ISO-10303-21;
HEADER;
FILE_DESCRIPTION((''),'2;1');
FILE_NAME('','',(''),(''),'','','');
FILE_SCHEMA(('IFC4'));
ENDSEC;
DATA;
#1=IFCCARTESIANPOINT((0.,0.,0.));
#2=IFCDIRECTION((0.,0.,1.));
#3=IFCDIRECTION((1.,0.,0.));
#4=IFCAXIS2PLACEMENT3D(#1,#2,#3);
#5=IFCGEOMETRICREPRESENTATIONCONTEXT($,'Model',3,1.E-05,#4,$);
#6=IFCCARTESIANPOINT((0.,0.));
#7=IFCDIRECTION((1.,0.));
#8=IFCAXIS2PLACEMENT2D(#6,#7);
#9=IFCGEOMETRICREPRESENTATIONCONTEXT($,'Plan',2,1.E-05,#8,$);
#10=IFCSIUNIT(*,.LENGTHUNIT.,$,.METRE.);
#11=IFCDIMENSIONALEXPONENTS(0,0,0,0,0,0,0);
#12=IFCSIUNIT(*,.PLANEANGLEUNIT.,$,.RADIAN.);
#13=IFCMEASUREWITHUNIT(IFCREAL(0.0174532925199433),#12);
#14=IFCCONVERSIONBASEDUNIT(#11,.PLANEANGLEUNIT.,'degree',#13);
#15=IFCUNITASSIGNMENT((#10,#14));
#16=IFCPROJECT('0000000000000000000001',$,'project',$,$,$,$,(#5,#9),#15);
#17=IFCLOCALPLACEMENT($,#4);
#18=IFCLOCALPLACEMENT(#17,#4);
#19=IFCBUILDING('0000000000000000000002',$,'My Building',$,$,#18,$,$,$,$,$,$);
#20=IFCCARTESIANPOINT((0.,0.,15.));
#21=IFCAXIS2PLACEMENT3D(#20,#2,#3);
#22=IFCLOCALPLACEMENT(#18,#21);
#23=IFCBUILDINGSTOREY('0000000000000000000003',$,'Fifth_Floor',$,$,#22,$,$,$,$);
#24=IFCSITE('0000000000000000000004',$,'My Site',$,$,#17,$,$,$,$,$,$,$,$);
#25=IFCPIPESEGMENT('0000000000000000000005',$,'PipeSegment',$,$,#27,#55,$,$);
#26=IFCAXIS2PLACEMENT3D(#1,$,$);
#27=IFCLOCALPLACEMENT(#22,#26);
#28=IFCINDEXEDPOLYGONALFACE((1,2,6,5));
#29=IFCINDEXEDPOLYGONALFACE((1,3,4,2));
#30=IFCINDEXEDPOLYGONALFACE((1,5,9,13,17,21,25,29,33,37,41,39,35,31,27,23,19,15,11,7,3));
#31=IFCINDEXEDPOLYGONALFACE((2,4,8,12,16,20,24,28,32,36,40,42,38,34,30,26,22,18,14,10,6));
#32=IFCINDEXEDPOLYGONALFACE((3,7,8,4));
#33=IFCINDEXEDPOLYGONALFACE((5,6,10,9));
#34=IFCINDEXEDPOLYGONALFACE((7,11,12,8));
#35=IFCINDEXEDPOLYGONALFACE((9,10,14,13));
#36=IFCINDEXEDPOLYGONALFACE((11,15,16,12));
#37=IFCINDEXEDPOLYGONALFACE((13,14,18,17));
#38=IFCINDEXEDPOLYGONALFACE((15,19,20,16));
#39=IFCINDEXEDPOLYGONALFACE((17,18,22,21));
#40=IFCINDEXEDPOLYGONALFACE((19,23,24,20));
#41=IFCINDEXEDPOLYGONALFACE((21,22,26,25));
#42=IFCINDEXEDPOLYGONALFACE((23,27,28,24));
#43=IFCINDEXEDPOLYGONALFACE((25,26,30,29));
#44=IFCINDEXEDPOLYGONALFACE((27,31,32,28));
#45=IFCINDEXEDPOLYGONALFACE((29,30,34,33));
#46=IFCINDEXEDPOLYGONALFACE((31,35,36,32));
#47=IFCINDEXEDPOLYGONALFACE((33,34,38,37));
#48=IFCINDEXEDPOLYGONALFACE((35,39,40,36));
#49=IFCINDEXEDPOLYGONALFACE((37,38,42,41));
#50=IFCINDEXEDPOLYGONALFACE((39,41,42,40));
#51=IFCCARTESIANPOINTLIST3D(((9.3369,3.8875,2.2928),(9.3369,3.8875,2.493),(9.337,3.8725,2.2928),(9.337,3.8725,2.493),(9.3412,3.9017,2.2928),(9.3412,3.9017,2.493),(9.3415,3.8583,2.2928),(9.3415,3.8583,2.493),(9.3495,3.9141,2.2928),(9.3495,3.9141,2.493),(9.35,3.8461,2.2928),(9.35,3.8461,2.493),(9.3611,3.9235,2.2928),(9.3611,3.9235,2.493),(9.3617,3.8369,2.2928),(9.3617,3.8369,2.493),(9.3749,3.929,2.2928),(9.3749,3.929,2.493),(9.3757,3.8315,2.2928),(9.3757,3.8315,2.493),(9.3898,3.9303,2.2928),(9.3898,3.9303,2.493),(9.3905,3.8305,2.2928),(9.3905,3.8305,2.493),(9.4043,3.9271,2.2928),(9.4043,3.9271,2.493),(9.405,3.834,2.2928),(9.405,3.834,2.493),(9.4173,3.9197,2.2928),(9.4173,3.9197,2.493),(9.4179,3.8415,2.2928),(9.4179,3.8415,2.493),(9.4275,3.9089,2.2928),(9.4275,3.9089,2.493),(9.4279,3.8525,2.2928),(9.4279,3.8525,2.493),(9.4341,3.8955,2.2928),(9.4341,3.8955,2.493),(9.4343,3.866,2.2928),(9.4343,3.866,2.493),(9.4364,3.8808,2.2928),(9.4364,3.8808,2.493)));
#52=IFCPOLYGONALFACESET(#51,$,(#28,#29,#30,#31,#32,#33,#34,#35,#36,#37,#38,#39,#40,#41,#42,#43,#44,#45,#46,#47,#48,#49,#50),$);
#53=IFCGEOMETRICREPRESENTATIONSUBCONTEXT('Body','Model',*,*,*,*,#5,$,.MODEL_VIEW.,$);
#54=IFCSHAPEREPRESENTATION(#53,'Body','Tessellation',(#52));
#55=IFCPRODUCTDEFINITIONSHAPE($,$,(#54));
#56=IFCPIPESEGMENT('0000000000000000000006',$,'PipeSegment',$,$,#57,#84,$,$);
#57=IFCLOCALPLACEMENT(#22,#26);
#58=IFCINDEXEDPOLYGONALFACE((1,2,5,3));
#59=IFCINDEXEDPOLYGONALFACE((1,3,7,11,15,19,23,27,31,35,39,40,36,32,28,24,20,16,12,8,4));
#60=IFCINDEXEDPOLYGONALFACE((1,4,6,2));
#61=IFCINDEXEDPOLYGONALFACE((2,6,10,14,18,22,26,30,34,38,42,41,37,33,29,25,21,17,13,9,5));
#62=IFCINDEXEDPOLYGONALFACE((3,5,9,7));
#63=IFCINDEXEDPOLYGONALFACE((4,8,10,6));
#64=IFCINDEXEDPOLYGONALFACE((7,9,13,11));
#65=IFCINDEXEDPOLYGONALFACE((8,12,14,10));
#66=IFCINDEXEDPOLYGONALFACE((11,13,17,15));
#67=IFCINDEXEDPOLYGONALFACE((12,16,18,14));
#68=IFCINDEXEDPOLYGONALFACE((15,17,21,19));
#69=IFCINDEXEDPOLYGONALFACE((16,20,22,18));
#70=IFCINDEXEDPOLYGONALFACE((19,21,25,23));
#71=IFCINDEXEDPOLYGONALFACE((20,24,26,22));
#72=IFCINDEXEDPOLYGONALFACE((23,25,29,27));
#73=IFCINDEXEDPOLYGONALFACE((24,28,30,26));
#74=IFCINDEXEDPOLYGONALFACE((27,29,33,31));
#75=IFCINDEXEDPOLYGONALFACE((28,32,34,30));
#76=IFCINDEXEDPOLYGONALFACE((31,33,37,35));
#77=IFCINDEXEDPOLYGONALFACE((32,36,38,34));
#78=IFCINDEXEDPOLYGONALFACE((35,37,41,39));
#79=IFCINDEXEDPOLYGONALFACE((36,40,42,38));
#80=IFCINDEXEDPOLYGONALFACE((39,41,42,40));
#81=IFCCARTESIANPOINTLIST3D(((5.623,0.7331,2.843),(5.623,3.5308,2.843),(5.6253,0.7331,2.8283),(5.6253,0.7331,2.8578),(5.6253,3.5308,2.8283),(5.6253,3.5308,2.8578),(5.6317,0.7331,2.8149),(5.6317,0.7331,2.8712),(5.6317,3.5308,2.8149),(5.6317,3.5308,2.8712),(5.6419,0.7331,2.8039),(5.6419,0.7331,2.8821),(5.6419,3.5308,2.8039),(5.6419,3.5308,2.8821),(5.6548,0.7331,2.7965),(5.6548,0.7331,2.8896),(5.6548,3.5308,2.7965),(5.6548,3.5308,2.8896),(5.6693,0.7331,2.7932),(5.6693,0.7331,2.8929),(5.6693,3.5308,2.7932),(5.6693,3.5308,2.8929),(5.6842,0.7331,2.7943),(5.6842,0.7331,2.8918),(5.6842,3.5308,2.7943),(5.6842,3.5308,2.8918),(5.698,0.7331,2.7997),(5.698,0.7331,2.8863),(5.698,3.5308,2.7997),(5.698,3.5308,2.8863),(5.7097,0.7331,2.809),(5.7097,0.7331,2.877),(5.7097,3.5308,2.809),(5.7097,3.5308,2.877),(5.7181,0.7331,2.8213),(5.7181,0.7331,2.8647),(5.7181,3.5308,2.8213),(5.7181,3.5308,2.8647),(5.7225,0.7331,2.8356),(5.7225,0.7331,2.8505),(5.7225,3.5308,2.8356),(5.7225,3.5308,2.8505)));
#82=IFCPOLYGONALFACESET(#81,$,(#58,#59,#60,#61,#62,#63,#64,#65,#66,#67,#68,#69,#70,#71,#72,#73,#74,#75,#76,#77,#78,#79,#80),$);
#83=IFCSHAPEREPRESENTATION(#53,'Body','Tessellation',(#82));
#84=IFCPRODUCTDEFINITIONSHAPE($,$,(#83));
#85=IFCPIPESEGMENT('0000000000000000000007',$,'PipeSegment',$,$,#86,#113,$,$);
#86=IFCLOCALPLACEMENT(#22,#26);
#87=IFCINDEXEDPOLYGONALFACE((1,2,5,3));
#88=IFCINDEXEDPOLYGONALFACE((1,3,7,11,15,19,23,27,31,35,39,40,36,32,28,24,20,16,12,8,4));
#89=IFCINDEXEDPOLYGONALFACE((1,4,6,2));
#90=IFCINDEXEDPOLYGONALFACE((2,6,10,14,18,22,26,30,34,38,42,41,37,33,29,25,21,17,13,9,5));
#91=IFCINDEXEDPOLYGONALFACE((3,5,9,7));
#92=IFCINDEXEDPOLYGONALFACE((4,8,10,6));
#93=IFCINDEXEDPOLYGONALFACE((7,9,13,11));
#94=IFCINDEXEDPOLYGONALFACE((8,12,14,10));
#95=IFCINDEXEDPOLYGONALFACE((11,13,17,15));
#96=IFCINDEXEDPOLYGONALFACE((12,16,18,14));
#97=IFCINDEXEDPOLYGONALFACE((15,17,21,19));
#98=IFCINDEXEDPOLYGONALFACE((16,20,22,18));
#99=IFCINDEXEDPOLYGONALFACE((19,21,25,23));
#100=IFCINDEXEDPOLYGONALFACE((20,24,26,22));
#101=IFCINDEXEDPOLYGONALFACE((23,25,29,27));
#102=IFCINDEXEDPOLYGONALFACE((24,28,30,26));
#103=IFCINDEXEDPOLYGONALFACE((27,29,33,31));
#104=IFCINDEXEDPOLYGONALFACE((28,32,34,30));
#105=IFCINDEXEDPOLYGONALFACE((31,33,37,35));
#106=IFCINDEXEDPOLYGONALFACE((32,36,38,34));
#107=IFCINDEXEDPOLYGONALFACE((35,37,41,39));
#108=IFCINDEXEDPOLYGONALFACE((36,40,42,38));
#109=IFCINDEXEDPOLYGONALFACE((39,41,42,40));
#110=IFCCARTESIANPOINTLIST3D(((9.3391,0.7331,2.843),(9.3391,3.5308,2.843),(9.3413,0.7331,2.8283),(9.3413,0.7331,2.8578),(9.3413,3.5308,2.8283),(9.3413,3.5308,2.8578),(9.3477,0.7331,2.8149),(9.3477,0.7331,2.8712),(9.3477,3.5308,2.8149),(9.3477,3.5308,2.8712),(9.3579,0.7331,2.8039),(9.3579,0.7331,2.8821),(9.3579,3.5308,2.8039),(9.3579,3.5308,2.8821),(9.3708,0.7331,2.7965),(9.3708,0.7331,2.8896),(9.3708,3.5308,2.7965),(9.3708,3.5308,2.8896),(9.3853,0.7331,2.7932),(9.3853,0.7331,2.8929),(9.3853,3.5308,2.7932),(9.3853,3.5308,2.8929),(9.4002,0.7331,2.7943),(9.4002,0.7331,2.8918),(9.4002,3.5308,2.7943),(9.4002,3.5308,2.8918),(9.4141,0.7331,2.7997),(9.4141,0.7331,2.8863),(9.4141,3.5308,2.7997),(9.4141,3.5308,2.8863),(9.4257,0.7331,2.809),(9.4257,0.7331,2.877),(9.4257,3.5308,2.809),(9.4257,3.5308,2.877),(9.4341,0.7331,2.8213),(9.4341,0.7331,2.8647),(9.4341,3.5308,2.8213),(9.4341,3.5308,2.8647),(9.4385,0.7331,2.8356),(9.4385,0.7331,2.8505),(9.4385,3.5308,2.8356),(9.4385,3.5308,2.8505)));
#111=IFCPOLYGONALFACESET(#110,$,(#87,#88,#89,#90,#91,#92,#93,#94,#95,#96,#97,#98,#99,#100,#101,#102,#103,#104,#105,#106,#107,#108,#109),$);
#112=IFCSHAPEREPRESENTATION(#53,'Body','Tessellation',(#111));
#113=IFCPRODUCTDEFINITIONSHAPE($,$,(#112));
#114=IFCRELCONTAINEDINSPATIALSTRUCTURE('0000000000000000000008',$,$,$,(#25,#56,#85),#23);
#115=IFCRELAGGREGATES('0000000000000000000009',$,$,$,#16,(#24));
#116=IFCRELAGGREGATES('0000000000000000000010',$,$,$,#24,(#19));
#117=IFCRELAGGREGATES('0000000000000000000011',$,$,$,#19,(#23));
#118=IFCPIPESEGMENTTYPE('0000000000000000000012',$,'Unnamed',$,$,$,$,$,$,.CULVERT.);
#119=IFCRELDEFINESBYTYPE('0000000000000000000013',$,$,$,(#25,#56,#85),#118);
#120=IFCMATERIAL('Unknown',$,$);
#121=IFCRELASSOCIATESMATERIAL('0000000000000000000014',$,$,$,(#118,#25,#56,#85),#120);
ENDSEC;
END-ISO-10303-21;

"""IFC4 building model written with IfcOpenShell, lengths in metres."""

from ifc_helpers import new_model, entity, si_unit, converted_unit, frame, origin_with_axes, origin_2d_with_axis, place, context, subcontext, project, spatial, circle, extrude, material, material_profile, profile_set, profile_usage, type_object, element, save


model = new_model("IFC4")

# Units and contexts
model_context = context("Model", 3, precision=1e-05, world=origin_with_axes())
plan_context = context("Plan", 2, precision=1e-05, world=origin_2d_with_axis())
body_context = subcontext(model_context, "Body", "Model", "MODEL_VIEW")
ifc_project = project(units=[si_unit("LENGTHUNIT", "METRE"), converted_unit("PLANEANGLEUNIT", "degree", entity("IfcReal", 0.0174532925199433), si_unit("PLANEANGLEUNIT", "RADIAN"), dimensions=[0, 0, 0, 0, 0, 0, 0])], contexts=[model_context, plan_context])

# Site, building, storey
site_placement = place(None, origin_with_axes())
site = spatial("IfcSite", under=ifc_project, at=site_placement, Name="My Site")
building_placement = place(site_placement, origin_with_axes())
building = spatial("IfcBuilding", under=site, at=building_placement, Name="My Building")
storey_placement = place(building_placement, frame((0.0, 0.0, 15.0), z_axis=(0.0, 0.0, 1.0), x_axis=(1.0, 0.0, 0.0)))
storey = spatial("IfcBuildingStorey", under=building, at=storey_placement, Name="Fifth_Floor")

# Pipe segments
ifc_material = material(Name="Unknown")
ifc_material_profile = material_profile(ifc_material, circle(Radius=0.05))
ifc_profile_set = profile_set([ifc_material_profile])
ifc_profile_usage_1 = profile_usage(ifc_profile_set, cardinal=5)
pipe_segment_type = type_object("IfcPipeSegmentType", Name="Unnamed", PredefinedType="CULVERT", material=ifc_profile_set)
pipe_segment_1_placement = place(storey_placement, frame((9.3864, 3.8804, 2.493), z_axis=(0.000001, 0.0, -1.0), x_axis=(0.999971, 0.007564, 0.000001)))
element("IfcPipeSegment", 1, at=pipe_segment_1_placement, inside=storey, type_object=pipe_segment_type, material=ifc_profile_usage_1, Name="PipeSegment", context=body_context, shape_type="SweptSolid", body=[
    extrude(circle(Radius=0.05), origin_with_axes(), (0.0, 0.0, 1.0), 0.2002),
])
ifc_profile_usage_2 = profile_usage(ifc_profile_set, cardinal=5)
pipe_segment_2_placement = place(storey_placement, frame((5.673, 0.7331, 2.843), z_axis=(0.0, 1.0, 0.0), x_axis=(-1.0, 0.0, 0.0)))
element("IfcPipeSegment", 2, at=pipe_segment_2_placement, inside=storey, type_object=pipe_segment_type, material=ifc_profile_usage_2, Name="PipeSegment", context=body_context, shape_type="SweptSolid", body=[
    extrude(circle(Radius=0.05), origin_with_axes(), (0.0, 0.0, 1.0), 2.7976),
])
ifc_profile_usage_3 = profile_usage(ifc_profile_set, cardinal=5)
pipe_segment_3_placement = place(storey_placement, frame((9.3891, 0.7331, 2.843), z_axis=(0.0, 1.0, 0.0), x_axis=(-1.0, 0.0, 0.0)))
element("IfcPipeSegment", 3, at=pipe_segment_3_placement, inside=storey, type_object=pipe_segment_type, material=ifc_profile_usage_3, Name="PipeSegment", context=body_context, shape_type="SweptSolid", body=[
    extrude(circle(Radius=0.05), origin_with_axes(), (0.0, 0.0, 1.0), 2.7976),
])

save(model, "model.ifc")
